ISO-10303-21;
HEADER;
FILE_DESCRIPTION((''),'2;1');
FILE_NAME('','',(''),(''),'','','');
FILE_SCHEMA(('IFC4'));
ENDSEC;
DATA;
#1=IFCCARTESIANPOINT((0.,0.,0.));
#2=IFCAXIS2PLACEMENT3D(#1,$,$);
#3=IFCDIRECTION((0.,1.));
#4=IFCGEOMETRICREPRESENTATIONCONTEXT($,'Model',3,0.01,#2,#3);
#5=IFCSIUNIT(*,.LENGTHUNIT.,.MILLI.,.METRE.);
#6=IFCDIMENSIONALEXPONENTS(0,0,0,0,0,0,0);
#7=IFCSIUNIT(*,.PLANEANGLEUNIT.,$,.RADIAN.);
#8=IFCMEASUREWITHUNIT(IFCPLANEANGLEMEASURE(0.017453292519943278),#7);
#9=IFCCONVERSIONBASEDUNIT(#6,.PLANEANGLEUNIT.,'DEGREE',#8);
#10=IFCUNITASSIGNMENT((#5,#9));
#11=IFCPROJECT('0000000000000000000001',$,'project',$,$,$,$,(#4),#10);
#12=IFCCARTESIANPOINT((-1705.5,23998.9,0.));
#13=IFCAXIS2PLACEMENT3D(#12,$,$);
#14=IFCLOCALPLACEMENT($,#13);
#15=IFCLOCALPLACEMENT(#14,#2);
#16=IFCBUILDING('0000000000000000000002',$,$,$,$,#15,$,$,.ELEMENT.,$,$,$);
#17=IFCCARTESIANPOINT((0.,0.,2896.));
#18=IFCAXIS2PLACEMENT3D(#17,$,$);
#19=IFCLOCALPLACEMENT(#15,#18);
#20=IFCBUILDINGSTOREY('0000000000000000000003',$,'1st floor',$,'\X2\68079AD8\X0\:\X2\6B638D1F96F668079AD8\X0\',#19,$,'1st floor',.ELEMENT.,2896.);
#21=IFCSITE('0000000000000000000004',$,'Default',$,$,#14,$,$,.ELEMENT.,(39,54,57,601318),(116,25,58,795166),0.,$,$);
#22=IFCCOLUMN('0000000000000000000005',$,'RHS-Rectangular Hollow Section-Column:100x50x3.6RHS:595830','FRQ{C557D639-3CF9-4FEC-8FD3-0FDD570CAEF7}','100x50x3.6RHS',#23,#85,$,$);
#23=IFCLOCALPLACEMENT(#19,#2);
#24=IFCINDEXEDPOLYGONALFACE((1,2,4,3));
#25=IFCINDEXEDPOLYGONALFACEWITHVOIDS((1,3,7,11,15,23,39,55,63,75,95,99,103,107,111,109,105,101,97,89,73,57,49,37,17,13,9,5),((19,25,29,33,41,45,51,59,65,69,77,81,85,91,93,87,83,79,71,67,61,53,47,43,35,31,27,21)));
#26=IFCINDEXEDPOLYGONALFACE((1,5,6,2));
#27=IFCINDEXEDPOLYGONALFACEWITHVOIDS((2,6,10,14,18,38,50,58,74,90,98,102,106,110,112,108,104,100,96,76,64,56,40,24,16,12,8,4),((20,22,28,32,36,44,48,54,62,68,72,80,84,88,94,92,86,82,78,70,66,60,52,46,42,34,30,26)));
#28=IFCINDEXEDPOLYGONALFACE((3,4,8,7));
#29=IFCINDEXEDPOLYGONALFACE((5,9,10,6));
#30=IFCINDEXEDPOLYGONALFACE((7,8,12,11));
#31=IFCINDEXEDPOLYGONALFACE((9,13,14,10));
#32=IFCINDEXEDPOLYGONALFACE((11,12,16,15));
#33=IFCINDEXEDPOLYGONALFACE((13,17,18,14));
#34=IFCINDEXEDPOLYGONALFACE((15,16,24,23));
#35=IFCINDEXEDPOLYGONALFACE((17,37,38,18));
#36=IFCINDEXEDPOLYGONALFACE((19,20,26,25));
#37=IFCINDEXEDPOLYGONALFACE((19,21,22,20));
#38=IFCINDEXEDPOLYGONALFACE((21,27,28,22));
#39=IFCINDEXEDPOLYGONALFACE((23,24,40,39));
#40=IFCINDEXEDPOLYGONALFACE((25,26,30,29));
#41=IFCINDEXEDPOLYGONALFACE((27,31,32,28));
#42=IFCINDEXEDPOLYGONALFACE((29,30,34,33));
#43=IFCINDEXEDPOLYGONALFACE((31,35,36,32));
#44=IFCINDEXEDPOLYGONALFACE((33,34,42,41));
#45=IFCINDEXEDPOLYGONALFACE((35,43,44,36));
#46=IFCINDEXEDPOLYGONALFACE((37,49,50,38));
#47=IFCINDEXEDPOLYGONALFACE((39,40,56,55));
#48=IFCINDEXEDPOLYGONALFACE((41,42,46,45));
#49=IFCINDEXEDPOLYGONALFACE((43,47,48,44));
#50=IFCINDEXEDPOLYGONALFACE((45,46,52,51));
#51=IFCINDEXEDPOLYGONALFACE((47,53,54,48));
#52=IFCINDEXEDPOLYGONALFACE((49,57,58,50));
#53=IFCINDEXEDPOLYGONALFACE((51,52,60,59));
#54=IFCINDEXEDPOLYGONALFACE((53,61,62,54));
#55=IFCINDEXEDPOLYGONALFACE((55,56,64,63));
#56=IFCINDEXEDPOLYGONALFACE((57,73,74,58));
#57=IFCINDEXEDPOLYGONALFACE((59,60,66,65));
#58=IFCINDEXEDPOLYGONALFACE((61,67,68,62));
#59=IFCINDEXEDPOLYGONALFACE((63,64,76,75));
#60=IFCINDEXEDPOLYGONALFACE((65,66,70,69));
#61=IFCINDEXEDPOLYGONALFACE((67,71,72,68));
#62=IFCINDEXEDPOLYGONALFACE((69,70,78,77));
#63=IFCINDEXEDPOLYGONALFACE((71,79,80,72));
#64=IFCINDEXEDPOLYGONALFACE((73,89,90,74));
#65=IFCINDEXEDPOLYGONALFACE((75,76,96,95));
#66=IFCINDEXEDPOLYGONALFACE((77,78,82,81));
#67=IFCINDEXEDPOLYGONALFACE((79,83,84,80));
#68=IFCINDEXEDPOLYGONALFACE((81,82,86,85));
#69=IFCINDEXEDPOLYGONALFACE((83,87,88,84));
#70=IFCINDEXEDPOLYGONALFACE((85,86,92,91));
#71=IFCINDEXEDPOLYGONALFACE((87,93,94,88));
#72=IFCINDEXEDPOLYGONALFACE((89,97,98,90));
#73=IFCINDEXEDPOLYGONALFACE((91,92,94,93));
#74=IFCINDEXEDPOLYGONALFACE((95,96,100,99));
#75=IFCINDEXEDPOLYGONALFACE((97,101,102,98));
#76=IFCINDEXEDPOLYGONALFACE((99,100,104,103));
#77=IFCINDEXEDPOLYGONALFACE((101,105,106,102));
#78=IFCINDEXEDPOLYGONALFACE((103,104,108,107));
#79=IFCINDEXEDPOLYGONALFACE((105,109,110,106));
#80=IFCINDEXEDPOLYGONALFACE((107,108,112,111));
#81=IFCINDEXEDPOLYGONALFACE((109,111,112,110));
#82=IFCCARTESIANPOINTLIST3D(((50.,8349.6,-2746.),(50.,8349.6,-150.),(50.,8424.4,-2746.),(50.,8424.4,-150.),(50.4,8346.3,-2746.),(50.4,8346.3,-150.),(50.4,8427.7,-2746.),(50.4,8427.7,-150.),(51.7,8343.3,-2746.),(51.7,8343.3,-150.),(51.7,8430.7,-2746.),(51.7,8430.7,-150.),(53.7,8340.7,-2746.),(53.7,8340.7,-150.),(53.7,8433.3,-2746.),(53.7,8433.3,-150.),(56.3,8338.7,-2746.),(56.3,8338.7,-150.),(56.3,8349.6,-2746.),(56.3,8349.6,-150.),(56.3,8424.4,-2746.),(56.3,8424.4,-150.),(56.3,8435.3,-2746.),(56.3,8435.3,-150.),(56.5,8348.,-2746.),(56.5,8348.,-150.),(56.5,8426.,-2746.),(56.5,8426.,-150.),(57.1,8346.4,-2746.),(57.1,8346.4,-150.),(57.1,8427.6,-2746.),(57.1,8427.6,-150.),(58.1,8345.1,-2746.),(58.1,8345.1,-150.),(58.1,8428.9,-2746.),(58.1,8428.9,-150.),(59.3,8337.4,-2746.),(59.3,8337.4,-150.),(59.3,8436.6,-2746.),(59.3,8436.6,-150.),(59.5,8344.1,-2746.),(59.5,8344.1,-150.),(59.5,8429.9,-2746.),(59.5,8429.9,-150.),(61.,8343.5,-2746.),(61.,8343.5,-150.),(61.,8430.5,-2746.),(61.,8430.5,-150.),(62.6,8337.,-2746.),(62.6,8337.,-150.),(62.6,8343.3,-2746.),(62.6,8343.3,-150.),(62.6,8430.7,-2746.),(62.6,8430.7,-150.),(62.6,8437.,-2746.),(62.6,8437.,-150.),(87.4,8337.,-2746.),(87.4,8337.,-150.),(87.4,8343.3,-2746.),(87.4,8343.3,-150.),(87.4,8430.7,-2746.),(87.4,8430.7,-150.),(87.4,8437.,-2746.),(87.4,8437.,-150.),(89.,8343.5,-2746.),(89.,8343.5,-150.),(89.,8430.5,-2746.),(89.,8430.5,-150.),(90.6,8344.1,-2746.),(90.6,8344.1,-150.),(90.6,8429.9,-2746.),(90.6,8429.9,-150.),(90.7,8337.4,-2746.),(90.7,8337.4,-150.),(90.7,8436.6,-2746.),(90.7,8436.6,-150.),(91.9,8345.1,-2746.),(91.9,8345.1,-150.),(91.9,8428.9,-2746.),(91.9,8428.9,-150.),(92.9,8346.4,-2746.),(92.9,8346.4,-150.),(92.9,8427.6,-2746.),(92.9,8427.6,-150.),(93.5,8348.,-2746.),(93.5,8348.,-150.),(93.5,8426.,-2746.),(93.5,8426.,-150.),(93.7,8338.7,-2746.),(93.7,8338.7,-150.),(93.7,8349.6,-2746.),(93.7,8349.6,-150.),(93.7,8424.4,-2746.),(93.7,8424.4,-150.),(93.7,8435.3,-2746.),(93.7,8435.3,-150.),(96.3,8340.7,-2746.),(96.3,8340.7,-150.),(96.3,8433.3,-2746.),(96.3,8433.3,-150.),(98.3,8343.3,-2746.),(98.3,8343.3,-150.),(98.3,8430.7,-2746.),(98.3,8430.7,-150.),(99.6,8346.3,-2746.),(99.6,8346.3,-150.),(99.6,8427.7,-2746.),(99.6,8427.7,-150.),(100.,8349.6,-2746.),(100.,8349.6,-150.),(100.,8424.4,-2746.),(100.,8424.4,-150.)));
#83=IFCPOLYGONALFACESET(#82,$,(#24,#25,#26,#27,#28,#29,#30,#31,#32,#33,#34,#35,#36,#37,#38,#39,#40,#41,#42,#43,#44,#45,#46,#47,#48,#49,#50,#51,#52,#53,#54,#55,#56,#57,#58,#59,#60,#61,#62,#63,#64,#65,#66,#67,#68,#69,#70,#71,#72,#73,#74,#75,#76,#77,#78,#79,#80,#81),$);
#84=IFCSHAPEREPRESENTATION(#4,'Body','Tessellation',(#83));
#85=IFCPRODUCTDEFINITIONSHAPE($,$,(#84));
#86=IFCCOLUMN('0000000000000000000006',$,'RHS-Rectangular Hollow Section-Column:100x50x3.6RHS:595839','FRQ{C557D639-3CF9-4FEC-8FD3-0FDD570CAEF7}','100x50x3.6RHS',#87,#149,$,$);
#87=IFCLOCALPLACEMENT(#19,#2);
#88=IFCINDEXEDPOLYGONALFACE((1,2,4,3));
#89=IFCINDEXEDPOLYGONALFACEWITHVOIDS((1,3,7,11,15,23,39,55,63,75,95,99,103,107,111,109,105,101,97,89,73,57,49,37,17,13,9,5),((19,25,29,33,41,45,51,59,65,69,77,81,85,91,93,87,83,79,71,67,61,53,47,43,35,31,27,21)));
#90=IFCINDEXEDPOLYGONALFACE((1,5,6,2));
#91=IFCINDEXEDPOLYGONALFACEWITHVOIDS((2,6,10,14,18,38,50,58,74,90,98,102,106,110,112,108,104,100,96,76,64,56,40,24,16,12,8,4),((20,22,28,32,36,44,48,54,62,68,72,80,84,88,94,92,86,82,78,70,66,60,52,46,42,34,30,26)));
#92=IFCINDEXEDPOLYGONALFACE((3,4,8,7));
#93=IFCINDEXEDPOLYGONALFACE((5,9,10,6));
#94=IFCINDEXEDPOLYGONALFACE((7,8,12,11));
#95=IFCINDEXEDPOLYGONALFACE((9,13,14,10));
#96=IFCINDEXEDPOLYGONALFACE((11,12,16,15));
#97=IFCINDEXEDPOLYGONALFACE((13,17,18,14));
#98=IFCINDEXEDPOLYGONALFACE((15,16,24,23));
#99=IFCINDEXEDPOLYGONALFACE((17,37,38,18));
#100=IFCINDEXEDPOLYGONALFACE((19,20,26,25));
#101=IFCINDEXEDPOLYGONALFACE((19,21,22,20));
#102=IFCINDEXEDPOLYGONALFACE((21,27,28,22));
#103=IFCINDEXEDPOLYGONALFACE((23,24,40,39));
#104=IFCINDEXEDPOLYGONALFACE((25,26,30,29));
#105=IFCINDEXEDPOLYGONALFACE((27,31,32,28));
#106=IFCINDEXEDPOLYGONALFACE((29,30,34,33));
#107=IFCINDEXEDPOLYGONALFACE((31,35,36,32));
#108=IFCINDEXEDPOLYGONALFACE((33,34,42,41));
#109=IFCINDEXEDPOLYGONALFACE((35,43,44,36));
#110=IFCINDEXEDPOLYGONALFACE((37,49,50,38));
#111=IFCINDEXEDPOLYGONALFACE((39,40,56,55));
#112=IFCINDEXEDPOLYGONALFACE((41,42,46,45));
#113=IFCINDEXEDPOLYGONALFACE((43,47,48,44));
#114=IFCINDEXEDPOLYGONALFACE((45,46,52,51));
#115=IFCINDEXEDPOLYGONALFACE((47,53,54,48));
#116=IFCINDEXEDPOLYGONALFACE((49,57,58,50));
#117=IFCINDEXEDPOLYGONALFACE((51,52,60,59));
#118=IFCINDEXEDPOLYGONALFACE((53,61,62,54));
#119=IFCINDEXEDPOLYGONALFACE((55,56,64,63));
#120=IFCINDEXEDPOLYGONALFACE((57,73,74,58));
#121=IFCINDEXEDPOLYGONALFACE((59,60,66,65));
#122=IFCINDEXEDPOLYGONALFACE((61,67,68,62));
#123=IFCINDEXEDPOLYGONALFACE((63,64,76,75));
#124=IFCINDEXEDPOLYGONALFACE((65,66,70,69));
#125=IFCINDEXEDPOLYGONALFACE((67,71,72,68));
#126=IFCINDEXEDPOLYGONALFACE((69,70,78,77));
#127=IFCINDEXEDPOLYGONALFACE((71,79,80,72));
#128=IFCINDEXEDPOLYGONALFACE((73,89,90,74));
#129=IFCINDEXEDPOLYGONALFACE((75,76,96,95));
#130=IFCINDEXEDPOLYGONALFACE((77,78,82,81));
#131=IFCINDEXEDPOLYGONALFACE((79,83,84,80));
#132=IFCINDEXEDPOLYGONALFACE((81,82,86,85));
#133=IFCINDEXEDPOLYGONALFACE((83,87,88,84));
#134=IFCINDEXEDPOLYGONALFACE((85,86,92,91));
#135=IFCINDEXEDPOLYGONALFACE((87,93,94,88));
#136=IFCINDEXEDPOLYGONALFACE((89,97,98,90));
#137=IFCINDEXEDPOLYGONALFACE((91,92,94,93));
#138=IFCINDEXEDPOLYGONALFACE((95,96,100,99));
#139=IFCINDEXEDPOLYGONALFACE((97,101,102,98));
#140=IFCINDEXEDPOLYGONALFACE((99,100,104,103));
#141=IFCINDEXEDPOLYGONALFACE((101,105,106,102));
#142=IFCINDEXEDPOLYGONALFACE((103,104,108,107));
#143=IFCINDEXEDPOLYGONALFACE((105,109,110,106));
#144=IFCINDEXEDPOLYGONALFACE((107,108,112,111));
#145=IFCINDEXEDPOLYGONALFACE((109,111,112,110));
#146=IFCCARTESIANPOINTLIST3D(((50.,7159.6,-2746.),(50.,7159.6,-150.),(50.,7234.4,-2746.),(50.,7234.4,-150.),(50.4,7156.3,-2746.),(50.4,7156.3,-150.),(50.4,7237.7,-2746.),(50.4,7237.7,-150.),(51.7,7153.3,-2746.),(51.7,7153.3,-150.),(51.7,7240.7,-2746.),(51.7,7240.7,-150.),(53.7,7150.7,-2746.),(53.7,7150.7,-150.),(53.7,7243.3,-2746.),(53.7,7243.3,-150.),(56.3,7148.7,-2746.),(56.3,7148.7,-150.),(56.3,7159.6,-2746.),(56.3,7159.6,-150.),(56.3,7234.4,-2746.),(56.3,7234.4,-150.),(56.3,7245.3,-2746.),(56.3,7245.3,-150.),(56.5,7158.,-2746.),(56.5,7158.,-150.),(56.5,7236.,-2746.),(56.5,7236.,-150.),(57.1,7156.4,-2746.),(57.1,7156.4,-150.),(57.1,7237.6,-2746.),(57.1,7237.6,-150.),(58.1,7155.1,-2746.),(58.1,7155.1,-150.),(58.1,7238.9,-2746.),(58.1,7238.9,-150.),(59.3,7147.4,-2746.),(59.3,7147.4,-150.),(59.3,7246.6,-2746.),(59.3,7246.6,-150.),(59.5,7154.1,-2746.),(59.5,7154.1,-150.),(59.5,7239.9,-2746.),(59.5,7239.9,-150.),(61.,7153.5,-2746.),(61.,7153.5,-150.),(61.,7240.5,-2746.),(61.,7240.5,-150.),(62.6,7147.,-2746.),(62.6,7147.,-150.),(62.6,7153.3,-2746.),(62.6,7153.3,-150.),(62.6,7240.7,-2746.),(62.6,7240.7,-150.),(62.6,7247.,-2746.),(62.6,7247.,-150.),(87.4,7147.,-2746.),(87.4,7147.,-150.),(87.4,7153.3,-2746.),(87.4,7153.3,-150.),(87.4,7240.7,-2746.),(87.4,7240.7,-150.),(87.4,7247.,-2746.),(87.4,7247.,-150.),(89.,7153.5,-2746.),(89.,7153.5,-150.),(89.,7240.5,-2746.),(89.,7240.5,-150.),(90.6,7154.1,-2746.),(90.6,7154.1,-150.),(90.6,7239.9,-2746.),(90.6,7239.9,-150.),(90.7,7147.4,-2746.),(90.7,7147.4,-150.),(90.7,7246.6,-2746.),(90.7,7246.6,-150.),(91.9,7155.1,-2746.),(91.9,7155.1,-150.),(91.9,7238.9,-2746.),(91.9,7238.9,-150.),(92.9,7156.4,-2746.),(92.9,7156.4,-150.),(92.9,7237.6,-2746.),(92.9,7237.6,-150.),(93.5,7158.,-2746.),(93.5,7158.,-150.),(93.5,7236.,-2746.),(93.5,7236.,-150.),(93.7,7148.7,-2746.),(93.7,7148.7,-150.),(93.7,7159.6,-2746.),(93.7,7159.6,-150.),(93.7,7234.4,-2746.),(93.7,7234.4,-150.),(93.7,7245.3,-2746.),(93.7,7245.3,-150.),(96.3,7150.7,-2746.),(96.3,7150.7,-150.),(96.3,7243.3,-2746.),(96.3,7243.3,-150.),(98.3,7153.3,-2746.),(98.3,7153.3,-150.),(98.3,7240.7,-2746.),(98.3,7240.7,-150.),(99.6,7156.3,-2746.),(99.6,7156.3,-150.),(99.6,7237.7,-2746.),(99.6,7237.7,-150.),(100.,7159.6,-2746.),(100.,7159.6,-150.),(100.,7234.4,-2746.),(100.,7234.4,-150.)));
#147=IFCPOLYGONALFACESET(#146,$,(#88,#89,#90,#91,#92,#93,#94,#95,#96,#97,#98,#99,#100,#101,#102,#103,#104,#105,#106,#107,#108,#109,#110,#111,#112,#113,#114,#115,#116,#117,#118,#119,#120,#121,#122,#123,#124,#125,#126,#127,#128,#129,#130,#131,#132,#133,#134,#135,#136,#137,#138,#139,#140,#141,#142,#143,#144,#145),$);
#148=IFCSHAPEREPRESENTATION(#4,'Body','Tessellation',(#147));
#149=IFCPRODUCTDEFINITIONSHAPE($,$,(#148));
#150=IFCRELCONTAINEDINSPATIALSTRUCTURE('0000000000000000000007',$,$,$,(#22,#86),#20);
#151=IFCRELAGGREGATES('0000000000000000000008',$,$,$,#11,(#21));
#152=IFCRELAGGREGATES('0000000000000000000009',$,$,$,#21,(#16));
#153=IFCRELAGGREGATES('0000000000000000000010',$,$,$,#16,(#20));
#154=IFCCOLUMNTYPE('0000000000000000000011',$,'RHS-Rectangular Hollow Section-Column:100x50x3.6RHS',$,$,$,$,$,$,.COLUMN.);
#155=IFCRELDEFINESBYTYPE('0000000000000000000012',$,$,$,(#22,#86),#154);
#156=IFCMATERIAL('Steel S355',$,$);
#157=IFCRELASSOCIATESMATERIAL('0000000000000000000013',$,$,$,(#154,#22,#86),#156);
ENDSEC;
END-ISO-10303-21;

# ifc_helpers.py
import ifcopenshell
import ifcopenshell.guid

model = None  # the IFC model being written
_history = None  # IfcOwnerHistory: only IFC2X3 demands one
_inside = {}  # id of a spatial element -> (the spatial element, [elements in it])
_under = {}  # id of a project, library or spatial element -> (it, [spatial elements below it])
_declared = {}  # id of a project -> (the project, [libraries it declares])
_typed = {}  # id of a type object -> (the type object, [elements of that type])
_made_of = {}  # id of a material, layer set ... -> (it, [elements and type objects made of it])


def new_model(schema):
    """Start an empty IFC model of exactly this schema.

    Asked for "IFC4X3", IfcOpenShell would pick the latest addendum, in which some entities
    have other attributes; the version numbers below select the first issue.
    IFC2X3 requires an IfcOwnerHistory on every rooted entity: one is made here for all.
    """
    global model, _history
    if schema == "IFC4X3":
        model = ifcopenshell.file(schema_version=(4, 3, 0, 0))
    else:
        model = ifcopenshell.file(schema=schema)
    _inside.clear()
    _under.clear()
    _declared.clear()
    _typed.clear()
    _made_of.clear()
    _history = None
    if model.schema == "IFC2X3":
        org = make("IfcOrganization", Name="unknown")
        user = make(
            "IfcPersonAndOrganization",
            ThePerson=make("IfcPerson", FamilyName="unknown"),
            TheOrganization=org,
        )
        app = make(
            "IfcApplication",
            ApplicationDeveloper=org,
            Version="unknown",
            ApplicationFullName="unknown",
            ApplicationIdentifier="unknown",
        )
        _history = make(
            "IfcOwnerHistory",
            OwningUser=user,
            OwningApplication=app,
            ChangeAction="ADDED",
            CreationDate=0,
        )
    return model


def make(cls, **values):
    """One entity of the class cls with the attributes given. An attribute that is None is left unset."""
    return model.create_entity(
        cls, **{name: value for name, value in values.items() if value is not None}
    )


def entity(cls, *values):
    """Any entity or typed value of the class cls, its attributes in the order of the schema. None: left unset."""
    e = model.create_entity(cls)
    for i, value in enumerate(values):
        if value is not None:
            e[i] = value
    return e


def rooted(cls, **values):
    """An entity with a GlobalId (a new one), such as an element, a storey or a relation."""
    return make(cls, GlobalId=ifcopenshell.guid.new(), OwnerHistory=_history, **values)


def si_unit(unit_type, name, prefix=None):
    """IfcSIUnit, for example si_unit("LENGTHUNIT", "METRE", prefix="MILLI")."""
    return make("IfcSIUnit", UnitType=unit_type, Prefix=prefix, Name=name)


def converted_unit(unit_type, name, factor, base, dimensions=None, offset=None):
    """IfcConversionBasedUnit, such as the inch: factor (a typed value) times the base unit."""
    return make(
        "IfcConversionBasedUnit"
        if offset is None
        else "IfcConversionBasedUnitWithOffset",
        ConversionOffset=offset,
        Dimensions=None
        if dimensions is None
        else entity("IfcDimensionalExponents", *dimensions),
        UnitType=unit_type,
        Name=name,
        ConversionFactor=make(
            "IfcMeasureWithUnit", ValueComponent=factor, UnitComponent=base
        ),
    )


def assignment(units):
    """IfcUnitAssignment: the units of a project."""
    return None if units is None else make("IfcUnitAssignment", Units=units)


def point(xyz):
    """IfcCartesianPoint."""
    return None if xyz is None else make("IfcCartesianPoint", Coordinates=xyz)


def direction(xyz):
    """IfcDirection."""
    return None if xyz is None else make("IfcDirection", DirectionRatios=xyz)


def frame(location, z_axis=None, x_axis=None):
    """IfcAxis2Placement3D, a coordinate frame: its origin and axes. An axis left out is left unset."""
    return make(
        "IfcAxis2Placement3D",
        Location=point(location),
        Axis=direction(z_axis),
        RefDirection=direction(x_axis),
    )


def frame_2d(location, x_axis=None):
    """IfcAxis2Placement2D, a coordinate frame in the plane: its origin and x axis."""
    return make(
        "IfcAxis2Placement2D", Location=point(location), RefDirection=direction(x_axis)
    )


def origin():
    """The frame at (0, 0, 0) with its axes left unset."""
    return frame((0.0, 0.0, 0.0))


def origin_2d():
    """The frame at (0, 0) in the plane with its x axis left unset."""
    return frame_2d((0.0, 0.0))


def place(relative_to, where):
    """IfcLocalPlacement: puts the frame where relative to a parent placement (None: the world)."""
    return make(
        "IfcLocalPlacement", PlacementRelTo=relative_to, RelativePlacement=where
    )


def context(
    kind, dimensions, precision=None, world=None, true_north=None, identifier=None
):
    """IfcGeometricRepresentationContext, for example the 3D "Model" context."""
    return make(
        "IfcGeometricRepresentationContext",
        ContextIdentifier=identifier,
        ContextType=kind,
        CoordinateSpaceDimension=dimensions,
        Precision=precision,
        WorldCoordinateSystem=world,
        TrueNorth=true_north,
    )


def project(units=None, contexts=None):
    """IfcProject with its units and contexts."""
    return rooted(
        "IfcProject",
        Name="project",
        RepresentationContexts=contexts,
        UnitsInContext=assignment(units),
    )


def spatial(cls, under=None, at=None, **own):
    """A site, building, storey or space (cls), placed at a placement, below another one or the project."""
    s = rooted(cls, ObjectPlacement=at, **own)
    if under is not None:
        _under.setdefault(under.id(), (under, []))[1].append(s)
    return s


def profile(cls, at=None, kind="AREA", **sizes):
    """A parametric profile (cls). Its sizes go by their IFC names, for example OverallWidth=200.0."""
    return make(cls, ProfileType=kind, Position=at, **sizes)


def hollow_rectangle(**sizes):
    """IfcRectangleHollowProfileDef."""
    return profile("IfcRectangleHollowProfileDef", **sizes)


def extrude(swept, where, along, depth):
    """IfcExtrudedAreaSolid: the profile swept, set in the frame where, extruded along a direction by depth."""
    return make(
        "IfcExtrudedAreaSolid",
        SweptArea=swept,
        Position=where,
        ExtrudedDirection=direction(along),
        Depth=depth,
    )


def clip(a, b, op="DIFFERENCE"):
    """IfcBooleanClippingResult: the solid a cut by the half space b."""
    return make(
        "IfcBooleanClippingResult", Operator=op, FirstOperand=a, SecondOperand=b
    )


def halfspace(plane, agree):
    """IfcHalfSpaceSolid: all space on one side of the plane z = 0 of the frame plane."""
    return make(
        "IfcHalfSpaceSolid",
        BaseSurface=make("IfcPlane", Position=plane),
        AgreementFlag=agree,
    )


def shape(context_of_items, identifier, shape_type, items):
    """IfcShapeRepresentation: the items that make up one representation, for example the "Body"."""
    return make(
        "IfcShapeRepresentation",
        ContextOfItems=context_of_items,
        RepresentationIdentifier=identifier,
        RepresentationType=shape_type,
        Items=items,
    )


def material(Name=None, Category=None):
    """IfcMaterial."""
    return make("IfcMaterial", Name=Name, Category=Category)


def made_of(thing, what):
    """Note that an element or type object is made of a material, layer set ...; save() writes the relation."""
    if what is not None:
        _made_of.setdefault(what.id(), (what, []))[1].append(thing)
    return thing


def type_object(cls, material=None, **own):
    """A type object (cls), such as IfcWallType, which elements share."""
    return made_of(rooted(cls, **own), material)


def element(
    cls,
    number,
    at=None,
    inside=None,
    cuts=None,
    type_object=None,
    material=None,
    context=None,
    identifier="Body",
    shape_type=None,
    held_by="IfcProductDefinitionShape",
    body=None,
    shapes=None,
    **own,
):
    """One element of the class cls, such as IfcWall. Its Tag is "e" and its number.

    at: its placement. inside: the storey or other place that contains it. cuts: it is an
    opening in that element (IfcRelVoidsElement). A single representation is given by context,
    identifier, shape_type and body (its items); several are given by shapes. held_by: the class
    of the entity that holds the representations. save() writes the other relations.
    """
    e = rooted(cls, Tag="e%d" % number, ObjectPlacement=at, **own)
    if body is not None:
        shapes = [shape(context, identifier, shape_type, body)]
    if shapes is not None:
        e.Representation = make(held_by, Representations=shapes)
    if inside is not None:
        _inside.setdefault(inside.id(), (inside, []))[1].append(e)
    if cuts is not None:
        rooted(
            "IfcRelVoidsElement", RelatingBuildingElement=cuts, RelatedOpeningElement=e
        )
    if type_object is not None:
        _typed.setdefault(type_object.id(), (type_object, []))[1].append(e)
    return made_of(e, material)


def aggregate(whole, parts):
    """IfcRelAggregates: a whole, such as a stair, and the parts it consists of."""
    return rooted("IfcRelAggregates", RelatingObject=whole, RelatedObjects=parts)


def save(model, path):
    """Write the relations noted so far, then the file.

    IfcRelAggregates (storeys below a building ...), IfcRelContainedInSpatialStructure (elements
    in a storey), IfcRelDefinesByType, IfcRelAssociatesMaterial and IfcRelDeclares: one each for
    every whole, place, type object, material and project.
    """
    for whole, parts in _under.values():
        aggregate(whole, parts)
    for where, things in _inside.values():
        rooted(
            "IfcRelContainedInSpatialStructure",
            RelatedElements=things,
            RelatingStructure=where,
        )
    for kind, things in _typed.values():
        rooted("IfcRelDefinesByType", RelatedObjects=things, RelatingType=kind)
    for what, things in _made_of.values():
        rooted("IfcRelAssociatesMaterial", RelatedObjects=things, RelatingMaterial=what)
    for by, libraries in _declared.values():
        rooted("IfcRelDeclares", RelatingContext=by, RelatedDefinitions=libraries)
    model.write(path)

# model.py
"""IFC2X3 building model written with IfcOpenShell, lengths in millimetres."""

from ifc_helpers import new_model, entity, si_unit, converted_unit, direction, frame, origin, origin_2d, place, context, project, spatial, hollow_rectangle, extrude, clip, halfspace, material, type_object, element, save


model = new_model("IFC2X3")

# Units and contexts
model_context = context("Model", 3, precision=0.01, world=origin(), true_north=direction((0.0, 1.0)))
ifc_project = project(units=[si_unit("LENGTHUNIT", "METRE", prefix="MILLI"), converted_unit("PLANEANGLEUNIT", "DEGREE", entity("IfcPlaneAngleMeasure", 0.017453292519943278), si_unit("PLANEANGLEUNIT", "RADIAN"), dimensions=[0, 0, 0, 0, 0, 0, 0])], contexts=[model_context])

# Site, building, storey
site_placement = place(None, frame((-1705.5, 23998.9, 0.0)))
site = spatial("IfcSite", under=ifc_project, at=site_placement, Name="Default", CompositionType="ELEMENT", RefLatitude=(39, 54, 57, 601318), RefLongitude=(116, 25, 58, 795166), RefElevation=0.0)
building_placement = place(site_placement, origin())
building = spatial("IfcBuilding", under=site, at=building_placement, CompositionType="ELEMENT")
storey_placement = place(building_placement, frame((0.0, 0.0, 2896.0)))
storey = spatial("IfcBuildingStorey", under=building, at=storey_placement, Name="1st floor", ObjectType="标高:正负零标高", LongName="1st floor", CompositionType="ELEMENT", Elevation=2896.0)

# Columns
ifc_material_1 = material(Name="Steel S355")
column_type = type_object("IfcColumnType", Name="RHS-Rectangular Hollow Section-Column:100x50x3.6RHS", PredefinedType="COLUMN", material=ifc_material_1)
column_1_placement = place(storey_placement, frame((75.0, 8387.0, -150.0), z_axis=(0.0, 0.0, 1.0), x_axis=(-1.0, 0.0, 0.0)))
element("IfcColumn", 1, at=column_1_placement, inside=storey, type_object=column_type, material=ifc_material_1, Name="RHS-Rectangular Hollow Section-Column:100x50x3.6RHS:595830", Description="FRQ{C557D639-3CF9-4FEC-8FD3-0FDD570CAEF7}", ObjectType="100x50x3.6RHS", context=model_context, shape_type="Clipping", body=[
    clip(extrude(hollow_rectangle(XDim=50.0, YDim=100.0, WallThickness=6.3, InnerFilletRadius=6.3, OuterFilletRadius=12.6, at=origin_2d()), origin(), (0.0, 0.0, -1.0), 2651.9), halfspace(frame((75.0, 8387.0, -2596.0), z_axis=(0.0, 0.0, 1.0), x_axis=(-1.0, 0.0, 0.0)), True)),
])
column_2_placement = place(storey_placement, frame((75.0, 7197.0, -150.0), z_axis=(0.0, 0.0, 1.0), x_axis=(-1.0, 0.0, 0.0)))
element("IfcColumn", 2, at=column_2_placement, inside=storey, type_object=column_type, material=ifc_material_1, Name="RHS-Rectangular Hollow Section-Column:100x50x3.6RHS:595839", Description="FRQ{C557D639-3CF9-4FEC-8FD3-0FDD570CAEF7}", ObjectType="100x50x3.6RHS", context=model_context, shape_type="Clipping", body=[
    clip(extrude(hollow_rectangle(XDim=50.0, YDim=100.0, WallThickness=6.3, InnerFilletRadius=6.3, OuterFilletRadius=12.6, at=origin_2d()), origin(), (0.0, 0.0, -1.0), 2651.9), halfspace(frame((75.0, 7197.0, -2596.0), z_axis=(0.0, 0.0, 1.0), x_axis=(-1.0, 0.0, 0.0)), True)),
])

save(model, "model.ifc")
